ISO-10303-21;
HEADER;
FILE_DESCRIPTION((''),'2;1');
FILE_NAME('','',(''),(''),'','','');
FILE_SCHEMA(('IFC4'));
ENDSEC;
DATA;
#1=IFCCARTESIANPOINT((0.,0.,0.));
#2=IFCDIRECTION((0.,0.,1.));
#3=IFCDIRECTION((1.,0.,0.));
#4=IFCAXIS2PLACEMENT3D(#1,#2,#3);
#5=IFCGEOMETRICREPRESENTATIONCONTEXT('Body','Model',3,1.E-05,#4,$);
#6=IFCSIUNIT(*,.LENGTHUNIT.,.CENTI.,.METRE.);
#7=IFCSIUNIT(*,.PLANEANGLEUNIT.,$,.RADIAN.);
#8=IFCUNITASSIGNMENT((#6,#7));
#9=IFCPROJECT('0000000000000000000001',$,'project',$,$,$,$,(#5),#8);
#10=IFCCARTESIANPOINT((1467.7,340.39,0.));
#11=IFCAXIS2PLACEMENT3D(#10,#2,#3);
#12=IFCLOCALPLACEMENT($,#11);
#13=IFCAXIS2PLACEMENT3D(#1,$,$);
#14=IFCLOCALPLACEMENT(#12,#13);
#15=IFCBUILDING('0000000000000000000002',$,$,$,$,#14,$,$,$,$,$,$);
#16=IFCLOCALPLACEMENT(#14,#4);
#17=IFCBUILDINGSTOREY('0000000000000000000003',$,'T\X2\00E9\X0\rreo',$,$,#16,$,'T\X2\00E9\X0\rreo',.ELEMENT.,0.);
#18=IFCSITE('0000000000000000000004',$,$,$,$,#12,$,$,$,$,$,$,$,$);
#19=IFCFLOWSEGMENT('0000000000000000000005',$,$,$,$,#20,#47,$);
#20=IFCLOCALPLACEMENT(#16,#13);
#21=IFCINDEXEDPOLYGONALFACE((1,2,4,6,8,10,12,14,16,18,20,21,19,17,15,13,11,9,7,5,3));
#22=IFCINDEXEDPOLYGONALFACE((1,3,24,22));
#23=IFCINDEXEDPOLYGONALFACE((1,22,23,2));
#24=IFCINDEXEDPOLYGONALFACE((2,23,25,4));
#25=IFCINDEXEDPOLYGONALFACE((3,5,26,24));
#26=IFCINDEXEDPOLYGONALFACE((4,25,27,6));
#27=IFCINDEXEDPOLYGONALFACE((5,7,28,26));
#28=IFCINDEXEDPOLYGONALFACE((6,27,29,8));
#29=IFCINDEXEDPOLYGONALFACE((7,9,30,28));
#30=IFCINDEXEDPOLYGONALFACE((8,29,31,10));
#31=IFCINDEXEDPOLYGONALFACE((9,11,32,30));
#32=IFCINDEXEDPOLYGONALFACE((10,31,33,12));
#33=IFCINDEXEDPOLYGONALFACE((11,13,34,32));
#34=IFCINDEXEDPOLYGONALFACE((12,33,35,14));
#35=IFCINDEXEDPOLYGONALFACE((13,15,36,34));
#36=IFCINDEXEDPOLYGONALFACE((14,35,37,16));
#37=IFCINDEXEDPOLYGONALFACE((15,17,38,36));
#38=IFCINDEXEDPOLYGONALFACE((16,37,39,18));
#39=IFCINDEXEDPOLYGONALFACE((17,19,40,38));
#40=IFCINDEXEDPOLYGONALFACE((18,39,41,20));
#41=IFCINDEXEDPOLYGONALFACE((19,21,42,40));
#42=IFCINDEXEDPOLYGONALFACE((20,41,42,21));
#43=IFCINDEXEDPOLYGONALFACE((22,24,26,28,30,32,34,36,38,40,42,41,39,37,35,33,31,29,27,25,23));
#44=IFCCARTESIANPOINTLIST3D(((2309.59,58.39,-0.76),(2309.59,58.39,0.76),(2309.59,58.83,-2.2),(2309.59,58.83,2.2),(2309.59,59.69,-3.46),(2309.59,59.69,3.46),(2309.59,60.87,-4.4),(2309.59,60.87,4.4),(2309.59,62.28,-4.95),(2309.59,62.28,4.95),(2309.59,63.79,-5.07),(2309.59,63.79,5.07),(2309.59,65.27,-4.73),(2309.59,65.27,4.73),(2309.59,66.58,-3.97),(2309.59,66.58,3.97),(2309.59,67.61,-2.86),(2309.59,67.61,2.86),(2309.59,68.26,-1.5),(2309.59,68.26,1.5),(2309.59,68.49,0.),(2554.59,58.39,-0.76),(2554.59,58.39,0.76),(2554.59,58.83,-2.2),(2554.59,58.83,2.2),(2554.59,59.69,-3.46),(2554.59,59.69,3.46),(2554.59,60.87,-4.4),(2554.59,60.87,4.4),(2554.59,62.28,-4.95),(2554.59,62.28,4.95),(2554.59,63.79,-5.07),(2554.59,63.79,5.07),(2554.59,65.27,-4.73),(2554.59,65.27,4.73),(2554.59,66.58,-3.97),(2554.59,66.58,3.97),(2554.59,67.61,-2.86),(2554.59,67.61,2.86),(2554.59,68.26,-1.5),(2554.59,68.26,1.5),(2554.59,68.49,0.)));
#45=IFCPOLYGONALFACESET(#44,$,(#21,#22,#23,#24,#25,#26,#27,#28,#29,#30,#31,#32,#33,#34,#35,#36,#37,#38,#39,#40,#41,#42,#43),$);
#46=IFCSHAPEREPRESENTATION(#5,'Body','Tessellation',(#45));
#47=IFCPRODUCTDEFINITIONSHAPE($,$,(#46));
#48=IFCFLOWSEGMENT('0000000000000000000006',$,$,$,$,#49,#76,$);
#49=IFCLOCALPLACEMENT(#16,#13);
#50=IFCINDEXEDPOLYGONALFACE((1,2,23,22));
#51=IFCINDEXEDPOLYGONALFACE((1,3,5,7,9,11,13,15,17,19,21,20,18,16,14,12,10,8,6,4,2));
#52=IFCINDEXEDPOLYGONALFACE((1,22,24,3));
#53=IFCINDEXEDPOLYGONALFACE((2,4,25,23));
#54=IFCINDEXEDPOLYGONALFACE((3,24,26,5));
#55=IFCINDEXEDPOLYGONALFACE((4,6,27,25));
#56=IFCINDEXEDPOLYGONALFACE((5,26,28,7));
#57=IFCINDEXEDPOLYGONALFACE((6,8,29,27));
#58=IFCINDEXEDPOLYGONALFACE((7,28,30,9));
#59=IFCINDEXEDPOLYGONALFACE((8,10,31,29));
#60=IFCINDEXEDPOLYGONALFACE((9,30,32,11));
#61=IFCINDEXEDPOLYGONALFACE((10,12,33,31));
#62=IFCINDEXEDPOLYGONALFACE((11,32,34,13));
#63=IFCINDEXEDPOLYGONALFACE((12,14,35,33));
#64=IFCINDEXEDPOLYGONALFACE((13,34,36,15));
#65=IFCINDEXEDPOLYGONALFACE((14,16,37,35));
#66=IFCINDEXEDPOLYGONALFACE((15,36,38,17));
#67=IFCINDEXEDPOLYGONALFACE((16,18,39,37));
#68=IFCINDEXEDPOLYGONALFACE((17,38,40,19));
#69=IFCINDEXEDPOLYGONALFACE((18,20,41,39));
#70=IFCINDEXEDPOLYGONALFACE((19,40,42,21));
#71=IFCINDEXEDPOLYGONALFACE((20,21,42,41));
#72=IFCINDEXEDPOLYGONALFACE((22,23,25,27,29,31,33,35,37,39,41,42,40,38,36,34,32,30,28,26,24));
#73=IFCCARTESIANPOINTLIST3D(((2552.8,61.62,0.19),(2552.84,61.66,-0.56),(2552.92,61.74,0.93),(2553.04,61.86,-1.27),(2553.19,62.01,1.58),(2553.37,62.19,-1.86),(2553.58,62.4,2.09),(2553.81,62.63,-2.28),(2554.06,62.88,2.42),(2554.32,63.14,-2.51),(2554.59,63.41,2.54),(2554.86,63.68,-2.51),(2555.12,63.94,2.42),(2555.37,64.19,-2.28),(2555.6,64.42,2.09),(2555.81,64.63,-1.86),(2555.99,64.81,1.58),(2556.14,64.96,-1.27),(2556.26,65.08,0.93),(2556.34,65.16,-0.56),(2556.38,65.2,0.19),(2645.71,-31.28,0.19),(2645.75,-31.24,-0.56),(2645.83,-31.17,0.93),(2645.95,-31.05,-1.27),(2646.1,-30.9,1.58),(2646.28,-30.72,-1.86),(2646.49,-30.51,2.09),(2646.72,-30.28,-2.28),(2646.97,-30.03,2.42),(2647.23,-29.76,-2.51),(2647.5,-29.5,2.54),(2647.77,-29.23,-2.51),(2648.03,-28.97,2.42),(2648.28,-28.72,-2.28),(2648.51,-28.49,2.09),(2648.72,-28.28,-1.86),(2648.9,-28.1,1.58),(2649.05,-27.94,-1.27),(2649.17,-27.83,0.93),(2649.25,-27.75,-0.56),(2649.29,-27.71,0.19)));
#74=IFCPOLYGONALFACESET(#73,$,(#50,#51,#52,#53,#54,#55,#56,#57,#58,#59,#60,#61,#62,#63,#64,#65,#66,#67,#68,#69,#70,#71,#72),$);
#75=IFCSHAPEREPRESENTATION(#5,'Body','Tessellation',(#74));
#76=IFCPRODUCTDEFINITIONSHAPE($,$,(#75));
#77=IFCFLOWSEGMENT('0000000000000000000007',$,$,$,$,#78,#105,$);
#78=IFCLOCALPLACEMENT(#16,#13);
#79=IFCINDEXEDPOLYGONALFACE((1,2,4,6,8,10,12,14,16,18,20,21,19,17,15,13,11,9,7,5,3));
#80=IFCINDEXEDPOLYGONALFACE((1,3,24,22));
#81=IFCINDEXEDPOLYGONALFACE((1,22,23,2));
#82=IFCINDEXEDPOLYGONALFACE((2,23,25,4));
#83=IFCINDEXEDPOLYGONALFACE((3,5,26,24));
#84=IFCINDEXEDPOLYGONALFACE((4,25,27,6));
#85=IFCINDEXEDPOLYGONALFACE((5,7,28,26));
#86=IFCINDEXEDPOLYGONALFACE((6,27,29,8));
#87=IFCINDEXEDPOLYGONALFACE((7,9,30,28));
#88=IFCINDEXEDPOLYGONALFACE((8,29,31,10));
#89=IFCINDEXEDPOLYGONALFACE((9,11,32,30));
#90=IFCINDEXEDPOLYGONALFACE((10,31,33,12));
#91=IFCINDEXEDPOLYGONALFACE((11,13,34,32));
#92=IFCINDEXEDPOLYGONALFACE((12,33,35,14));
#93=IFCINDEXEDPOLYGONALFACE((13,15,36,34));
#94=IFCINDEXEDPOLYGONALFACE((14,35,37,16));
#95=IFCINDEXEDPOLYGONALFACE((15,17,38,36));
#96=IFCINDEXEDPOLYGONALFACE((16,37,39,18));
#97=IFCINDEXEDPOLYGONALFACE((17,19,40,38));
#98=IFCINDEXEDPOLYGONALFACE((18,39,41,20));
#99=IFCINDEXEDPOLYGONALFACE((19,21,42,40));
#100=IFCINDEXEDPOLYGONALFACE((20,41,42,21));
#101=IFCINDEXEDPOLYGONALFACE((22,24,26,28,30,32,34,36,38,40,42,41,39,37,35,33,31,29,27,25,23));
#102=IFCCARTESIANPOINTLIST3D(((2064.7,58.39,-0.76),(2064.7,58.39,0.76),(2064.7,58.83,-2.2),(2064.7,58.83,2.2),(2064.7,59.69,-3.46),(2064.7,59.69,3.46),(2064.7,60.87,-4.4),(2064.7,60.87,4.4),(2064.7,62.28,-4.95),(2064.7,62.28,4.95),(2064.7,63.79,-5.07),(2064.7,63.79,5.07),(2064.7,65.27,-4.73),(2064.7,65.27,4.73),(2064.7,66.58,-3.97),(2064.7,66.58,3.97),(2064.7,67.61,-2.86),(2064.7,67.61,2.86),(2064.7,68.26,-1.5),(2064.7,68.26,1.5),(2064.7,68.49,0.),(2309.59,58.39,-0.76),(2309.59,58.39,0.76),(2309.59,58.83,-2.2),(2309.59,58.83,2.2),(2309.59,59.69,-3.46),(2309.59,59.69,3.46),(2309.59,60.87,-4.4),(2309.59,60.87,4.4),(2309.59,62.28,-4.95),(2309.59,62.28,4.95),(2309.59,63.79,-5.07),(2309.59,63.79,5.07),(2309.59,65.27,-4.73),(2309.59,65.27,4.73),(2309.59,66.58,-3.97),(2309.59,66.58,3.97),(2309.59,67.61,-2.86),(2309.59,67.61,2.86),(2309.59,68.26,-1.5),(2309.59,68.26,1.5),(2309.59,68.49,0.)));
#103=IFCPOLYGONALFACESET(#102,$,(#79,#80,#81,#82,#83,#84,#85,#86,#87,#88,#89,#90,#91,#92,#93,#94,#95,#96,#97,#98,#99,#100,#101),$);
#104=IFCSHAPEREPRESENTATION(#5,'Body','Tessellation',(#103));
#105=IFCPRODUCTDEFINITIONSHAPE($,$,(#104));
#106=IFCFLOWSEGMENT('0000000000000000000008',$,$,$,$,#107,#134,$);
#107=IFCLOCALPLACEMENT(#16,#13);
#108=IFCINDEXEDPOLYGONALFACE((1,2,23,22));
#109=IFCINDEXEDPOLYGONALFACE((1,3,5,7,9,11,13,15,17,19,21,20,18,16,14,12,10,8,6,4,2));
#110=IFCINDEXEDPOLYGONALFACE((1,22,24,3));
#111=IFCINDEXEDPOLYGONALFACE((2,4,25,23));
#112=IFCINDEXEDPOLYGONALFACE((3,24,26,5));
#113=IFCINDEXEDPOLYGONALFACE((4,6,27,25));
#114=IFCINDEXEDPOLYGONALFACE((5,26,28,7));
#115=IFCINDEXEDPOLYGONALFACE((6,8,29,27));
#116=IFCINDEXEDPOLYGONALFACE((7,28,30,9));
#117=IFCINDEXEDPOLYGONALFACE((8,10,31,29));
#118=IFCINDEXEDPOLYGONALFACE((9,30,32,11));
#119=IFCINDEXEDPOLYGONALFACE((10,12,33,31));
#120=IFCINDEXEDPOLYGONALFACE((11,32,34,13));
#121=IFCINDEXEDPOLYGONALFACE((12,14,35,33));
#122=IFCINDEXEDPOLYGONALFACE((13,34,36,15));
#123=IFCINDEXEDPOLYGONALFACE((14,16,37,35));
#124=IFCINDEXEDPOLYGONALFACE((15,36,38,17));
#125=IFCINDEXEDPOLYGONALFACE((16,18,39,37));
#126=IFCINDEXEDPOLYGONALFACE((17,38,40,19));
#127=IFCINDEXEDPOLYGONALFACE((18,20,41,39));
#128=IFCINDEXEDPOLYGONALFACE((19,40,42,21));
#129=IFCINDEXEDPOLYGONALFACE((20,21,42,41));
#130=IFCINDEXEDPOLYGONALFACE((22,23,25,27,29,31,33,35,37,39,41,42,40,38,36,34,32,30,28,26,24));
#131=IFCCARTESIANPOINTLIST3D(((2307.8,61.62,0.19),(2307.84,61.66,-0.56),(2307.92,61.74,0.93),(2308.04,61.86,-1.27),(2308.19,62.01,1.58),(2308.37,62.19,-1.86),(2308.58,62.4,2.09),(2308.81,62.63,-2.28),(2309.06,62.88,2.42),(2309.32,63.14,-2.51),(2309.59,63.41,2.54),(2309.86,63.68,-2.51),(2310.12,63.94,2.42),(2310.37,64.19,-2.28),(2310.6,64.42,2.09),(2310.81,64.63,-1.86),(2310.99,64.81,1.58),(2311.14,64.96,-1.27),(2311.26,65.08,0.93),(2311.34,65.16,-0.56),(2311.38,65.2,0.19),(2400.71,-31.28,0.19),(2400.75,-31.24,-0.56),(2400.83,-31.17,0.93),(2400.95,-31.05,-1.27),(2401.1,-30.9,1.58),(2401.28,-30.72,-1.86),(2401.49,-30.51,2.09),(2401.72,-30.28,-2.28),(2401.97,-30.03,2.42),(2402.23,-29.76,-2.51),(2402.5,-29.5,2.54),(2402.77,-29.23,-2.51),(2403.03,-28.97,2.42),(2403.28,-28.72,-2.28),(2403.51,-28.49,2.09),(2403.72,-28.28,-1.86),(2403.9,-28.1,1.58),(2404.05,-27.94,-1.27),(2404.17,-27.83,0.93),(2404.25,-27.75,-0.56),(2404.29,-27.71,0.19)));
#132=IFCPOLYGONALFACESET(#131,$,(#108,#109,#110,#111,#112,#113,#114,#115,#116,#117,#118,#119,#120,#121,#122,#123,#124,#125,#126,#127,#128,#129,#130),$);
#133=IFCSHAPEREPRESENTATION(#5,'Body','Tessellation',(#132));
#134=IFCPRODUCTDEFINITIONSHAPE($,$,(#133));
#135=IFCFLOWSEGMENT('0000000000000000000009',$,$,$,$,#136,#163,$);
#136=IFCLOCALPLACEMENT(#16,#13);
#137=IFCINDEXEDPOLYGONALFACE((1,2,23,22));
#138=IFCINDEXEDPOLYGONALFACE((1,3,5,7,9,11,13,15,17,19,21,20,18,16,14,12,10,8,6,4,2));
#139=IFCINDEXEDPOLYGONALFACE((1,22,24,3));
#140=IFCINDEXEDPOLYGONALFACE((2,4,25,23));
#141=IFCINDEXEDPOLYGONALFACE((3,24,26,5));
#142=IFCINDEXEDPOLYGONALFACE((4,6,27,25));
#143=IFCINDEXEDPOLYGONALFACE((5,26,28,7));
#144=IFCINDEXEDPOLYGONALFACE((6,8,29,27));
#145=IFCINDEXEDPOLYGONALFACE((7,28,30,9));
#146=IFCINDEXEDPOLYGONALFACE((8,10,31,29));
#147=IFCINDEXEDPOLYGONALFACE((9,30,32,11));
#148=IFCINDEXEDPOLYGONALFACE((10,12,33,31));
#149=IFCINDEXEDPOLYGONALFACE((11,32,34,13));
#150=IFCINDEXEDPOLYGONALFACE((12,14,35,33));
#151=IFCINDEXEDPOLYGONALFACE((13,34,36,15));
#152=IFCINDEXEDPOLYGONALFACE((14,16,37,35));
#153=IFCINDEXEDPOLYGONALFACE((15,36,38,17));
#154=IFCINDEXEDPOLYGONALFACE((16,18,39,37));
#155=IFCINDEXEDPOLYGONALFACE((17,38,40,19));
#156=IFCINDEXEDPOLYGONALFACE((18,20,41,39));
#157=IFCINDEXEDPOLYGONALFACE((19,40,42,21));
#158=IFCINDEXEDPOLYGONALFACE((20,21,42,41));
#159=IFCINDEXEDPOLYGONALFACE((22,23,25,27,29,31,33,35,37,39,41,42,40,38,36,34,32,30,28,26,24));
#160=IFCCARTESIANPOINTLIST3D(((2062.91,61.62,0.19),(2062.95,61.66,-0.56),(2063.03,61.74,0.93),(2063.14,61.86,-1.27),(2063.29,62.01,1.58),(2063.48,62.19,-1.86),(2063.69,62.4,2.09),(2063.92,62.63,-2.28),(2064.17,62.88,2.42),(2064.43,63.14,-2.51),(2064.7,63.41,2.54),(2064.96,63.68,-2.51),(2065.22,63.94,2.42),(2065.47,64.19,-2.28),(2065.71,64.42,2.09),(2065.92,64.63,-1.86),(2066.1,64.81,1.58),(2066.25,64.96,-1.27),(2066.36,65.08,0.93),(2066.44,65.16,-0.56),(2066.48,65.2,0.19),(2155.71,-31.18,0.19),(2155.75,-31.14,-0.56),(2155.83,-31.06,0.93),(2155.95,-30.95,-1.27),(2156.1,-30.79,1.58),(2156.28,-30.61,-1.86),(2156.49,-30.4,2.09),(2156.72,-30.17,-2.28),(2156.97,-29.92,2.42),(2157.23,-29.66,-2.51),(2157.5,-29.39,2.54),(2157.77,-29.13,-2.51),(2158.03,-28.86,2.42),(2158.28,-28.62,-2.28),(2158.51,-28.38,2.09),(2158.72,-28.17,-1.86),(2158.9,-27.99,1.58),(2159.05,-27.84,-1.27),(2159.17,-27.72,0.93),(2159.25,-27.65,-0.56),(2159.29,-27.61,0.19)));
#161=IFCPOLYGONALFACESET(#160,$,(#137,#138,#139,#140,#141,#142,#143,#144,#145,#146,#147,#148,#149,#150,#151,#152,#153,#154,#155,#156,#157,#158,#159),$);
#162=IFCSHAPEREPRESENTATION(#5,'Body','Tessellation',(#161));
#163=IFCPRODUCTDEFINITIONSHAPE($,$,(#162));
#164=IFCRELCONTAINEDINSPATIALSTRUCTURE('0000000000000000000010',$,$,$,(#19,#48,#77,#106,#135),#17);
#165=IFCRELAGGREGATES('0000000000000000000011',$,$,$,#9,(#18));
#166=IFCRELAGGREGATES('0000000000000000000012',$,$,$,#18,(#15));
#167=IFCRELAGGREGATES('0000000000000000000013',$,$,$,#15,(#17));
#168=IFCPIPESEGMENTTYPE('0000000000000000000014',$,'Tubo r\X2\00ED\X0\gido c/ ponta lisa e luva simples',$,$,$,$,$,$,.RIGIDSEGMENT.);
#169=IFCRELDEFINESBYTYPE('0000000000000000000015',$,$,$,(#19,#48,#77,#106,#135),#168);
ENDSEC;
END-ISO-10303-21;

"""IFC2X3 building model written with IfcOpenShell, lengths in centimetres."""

from ifc_helpers import new_model, si_unit, frame, origin, origin_with_axes, origin_2d_with_axis, place, context, project, spatial, circle, extrude, type_object, element, save


model = new_model("IFC2X3")

# Units and contexts
model_context = context("Model", 3, precision=1e-05, world=origin_with_axes(), identifier="Body")
ifc_project = project(units=[si_unit("LENGTHUNIT", "METRE", prefix="CENTI"), si_unit("PLANEANGLEUNIT", "RADIAN")], contexts=[model_context])

# Site, building, storey
site_placement = place(None, frame((1467.7, 340.39, 0.0), z_axis=(0.0, 0.0, 1.0), x_axis=(1.0, 0.0, 0.0)))
site = spatial("IfcSite", under=ifc_project, at=site_placement)
building_placement = place(site_placement, origin())
building = spatial("IfcBuilding", under=site, at=building_placement)
storey_placement = place(building_placement, origin_with_axes())
storey = spatial("IfcBuildingStorey", under=building, at=storey_placement, Name="Térreo", LongName="Térreo", CompositionType="ELEMENT", Elevation=0.0)

# Flow segments
pipe_segment_type_1 = type_object("IfcPipeSegmentType", Name="Tubo rígido c/ ponta lisa e luva simples", PredefinedType="RIGIDSEGMENT")
flow_segment_1_placement = place(storey_placement, frame((2432.09, 63.41, 5.08), z_axis=(0.0, 0.0, 1.0), x_axis=(1.0, 0.0, 0.0)))
element("IfcFlowSegment", 1, at=flow_segment_1_placement, inside=storey, type_object=pipe_segment_type_1, context=model_context, shape_type="SolidModel", body=[
    extrude(circle(Radius=5.08, at=origin_2d_with_axis()), frame((122.5, 0.0, -5.08), z_axis=(-1.0, 0.0, 0.0), x_axis=(0.0, 1.0, 0.0)), (0.0, 0.0, 1.0), 245.0),
])
flow_segment_2_placement = place(storey_placement, frame((2601.05, 16.96, 2.54), z_axis=(0.0, 0.0, 1.0), x_axis=(1.0, 0.0, 0.0)))
element("IfcFlowSegment", 2, at=flow_segment_2_placement, inside=storey, type_object=pipe_segment_type_1, context=model_context, shape_type="SolidModel", body=[
    extrude(circle(Radius=2.54, at=origin_2d_with_axis()), frame((46.45, -46.45, -2.54), z_axis=(-0.707107, 0.707107, 0.0), x_axis=(0.0, 0.0, 1.0)), (0.0, 0.0, 1.0), 131.39),
])
flow_segment_3_placement = place(storey_placement, frame((2187.14, 63.41, 5.08), z_axis=(0.0, 0.0, 1.0), x_axis=(1.0, 0.0, 0.0)))
element("IfcFlowSegment", 3, at=flow_segment_3_placement, inside=storey, type_object=pipe_segment_type_1, context=model_context, shape_type="SolidModel", body=[
    extrude(circle(Radius=5.08, at=origin_2d_with_axis()), frame((122.45, 0.0, -5.08), z_axis=(-1.0, 0.0, 0.0), x_axis=(0.0, 1.0, 0.0)), (0.0, 0.0, 1.0), 244.9),
])
flow_segment_4_placement = place(storey_placement, frame((2356.05, 16.96, 2.54), z_axis=(0.0, 0.0, 1.0), x_axis=(1.0, 0.0, 0.0)))
element("IfcFlowSegment", 4, at=flow_segment_4_placement, inside=storey, type_object=pipe_segment_type_1, context=model_context, shape_type="SolidModel", body=[
    extrude(circle(Radius=2.54, at=origin_2d_with_axis()), frame((46.45, -46.45, -2.54), z_axis=(-0.707107, 0.707107, 0.0), x_axis=(0.0, 0.0, 1.0)), (0.0, 0.0, 1.0), 131.39),
])
flow_segment_5_placement = place(storey_placement, frame((2111.1, 17.01, 2.54), z_axis=(0.0, 0.0, 1.0), x_axis=(1.0, 0.0, 0.0)))
element("IfcFlowSegment", 5, at=flow_segment_5_placement, inside=storey, type_object=pipe_segment_type_1, context=model_context, shape_type="SolidModel", body=[
    extrude(circle(Radius=2.54, at=origin_2d_with_axis()), frame((46.4, -46.4, -2.54), z_axis=(-0.707107, 0.707107, 0.0), x_axis=(0.0, 0.0, 1.0)), (0.0, 0.0, 1.0), 131.24),
])

save(model, "model.ifc")
